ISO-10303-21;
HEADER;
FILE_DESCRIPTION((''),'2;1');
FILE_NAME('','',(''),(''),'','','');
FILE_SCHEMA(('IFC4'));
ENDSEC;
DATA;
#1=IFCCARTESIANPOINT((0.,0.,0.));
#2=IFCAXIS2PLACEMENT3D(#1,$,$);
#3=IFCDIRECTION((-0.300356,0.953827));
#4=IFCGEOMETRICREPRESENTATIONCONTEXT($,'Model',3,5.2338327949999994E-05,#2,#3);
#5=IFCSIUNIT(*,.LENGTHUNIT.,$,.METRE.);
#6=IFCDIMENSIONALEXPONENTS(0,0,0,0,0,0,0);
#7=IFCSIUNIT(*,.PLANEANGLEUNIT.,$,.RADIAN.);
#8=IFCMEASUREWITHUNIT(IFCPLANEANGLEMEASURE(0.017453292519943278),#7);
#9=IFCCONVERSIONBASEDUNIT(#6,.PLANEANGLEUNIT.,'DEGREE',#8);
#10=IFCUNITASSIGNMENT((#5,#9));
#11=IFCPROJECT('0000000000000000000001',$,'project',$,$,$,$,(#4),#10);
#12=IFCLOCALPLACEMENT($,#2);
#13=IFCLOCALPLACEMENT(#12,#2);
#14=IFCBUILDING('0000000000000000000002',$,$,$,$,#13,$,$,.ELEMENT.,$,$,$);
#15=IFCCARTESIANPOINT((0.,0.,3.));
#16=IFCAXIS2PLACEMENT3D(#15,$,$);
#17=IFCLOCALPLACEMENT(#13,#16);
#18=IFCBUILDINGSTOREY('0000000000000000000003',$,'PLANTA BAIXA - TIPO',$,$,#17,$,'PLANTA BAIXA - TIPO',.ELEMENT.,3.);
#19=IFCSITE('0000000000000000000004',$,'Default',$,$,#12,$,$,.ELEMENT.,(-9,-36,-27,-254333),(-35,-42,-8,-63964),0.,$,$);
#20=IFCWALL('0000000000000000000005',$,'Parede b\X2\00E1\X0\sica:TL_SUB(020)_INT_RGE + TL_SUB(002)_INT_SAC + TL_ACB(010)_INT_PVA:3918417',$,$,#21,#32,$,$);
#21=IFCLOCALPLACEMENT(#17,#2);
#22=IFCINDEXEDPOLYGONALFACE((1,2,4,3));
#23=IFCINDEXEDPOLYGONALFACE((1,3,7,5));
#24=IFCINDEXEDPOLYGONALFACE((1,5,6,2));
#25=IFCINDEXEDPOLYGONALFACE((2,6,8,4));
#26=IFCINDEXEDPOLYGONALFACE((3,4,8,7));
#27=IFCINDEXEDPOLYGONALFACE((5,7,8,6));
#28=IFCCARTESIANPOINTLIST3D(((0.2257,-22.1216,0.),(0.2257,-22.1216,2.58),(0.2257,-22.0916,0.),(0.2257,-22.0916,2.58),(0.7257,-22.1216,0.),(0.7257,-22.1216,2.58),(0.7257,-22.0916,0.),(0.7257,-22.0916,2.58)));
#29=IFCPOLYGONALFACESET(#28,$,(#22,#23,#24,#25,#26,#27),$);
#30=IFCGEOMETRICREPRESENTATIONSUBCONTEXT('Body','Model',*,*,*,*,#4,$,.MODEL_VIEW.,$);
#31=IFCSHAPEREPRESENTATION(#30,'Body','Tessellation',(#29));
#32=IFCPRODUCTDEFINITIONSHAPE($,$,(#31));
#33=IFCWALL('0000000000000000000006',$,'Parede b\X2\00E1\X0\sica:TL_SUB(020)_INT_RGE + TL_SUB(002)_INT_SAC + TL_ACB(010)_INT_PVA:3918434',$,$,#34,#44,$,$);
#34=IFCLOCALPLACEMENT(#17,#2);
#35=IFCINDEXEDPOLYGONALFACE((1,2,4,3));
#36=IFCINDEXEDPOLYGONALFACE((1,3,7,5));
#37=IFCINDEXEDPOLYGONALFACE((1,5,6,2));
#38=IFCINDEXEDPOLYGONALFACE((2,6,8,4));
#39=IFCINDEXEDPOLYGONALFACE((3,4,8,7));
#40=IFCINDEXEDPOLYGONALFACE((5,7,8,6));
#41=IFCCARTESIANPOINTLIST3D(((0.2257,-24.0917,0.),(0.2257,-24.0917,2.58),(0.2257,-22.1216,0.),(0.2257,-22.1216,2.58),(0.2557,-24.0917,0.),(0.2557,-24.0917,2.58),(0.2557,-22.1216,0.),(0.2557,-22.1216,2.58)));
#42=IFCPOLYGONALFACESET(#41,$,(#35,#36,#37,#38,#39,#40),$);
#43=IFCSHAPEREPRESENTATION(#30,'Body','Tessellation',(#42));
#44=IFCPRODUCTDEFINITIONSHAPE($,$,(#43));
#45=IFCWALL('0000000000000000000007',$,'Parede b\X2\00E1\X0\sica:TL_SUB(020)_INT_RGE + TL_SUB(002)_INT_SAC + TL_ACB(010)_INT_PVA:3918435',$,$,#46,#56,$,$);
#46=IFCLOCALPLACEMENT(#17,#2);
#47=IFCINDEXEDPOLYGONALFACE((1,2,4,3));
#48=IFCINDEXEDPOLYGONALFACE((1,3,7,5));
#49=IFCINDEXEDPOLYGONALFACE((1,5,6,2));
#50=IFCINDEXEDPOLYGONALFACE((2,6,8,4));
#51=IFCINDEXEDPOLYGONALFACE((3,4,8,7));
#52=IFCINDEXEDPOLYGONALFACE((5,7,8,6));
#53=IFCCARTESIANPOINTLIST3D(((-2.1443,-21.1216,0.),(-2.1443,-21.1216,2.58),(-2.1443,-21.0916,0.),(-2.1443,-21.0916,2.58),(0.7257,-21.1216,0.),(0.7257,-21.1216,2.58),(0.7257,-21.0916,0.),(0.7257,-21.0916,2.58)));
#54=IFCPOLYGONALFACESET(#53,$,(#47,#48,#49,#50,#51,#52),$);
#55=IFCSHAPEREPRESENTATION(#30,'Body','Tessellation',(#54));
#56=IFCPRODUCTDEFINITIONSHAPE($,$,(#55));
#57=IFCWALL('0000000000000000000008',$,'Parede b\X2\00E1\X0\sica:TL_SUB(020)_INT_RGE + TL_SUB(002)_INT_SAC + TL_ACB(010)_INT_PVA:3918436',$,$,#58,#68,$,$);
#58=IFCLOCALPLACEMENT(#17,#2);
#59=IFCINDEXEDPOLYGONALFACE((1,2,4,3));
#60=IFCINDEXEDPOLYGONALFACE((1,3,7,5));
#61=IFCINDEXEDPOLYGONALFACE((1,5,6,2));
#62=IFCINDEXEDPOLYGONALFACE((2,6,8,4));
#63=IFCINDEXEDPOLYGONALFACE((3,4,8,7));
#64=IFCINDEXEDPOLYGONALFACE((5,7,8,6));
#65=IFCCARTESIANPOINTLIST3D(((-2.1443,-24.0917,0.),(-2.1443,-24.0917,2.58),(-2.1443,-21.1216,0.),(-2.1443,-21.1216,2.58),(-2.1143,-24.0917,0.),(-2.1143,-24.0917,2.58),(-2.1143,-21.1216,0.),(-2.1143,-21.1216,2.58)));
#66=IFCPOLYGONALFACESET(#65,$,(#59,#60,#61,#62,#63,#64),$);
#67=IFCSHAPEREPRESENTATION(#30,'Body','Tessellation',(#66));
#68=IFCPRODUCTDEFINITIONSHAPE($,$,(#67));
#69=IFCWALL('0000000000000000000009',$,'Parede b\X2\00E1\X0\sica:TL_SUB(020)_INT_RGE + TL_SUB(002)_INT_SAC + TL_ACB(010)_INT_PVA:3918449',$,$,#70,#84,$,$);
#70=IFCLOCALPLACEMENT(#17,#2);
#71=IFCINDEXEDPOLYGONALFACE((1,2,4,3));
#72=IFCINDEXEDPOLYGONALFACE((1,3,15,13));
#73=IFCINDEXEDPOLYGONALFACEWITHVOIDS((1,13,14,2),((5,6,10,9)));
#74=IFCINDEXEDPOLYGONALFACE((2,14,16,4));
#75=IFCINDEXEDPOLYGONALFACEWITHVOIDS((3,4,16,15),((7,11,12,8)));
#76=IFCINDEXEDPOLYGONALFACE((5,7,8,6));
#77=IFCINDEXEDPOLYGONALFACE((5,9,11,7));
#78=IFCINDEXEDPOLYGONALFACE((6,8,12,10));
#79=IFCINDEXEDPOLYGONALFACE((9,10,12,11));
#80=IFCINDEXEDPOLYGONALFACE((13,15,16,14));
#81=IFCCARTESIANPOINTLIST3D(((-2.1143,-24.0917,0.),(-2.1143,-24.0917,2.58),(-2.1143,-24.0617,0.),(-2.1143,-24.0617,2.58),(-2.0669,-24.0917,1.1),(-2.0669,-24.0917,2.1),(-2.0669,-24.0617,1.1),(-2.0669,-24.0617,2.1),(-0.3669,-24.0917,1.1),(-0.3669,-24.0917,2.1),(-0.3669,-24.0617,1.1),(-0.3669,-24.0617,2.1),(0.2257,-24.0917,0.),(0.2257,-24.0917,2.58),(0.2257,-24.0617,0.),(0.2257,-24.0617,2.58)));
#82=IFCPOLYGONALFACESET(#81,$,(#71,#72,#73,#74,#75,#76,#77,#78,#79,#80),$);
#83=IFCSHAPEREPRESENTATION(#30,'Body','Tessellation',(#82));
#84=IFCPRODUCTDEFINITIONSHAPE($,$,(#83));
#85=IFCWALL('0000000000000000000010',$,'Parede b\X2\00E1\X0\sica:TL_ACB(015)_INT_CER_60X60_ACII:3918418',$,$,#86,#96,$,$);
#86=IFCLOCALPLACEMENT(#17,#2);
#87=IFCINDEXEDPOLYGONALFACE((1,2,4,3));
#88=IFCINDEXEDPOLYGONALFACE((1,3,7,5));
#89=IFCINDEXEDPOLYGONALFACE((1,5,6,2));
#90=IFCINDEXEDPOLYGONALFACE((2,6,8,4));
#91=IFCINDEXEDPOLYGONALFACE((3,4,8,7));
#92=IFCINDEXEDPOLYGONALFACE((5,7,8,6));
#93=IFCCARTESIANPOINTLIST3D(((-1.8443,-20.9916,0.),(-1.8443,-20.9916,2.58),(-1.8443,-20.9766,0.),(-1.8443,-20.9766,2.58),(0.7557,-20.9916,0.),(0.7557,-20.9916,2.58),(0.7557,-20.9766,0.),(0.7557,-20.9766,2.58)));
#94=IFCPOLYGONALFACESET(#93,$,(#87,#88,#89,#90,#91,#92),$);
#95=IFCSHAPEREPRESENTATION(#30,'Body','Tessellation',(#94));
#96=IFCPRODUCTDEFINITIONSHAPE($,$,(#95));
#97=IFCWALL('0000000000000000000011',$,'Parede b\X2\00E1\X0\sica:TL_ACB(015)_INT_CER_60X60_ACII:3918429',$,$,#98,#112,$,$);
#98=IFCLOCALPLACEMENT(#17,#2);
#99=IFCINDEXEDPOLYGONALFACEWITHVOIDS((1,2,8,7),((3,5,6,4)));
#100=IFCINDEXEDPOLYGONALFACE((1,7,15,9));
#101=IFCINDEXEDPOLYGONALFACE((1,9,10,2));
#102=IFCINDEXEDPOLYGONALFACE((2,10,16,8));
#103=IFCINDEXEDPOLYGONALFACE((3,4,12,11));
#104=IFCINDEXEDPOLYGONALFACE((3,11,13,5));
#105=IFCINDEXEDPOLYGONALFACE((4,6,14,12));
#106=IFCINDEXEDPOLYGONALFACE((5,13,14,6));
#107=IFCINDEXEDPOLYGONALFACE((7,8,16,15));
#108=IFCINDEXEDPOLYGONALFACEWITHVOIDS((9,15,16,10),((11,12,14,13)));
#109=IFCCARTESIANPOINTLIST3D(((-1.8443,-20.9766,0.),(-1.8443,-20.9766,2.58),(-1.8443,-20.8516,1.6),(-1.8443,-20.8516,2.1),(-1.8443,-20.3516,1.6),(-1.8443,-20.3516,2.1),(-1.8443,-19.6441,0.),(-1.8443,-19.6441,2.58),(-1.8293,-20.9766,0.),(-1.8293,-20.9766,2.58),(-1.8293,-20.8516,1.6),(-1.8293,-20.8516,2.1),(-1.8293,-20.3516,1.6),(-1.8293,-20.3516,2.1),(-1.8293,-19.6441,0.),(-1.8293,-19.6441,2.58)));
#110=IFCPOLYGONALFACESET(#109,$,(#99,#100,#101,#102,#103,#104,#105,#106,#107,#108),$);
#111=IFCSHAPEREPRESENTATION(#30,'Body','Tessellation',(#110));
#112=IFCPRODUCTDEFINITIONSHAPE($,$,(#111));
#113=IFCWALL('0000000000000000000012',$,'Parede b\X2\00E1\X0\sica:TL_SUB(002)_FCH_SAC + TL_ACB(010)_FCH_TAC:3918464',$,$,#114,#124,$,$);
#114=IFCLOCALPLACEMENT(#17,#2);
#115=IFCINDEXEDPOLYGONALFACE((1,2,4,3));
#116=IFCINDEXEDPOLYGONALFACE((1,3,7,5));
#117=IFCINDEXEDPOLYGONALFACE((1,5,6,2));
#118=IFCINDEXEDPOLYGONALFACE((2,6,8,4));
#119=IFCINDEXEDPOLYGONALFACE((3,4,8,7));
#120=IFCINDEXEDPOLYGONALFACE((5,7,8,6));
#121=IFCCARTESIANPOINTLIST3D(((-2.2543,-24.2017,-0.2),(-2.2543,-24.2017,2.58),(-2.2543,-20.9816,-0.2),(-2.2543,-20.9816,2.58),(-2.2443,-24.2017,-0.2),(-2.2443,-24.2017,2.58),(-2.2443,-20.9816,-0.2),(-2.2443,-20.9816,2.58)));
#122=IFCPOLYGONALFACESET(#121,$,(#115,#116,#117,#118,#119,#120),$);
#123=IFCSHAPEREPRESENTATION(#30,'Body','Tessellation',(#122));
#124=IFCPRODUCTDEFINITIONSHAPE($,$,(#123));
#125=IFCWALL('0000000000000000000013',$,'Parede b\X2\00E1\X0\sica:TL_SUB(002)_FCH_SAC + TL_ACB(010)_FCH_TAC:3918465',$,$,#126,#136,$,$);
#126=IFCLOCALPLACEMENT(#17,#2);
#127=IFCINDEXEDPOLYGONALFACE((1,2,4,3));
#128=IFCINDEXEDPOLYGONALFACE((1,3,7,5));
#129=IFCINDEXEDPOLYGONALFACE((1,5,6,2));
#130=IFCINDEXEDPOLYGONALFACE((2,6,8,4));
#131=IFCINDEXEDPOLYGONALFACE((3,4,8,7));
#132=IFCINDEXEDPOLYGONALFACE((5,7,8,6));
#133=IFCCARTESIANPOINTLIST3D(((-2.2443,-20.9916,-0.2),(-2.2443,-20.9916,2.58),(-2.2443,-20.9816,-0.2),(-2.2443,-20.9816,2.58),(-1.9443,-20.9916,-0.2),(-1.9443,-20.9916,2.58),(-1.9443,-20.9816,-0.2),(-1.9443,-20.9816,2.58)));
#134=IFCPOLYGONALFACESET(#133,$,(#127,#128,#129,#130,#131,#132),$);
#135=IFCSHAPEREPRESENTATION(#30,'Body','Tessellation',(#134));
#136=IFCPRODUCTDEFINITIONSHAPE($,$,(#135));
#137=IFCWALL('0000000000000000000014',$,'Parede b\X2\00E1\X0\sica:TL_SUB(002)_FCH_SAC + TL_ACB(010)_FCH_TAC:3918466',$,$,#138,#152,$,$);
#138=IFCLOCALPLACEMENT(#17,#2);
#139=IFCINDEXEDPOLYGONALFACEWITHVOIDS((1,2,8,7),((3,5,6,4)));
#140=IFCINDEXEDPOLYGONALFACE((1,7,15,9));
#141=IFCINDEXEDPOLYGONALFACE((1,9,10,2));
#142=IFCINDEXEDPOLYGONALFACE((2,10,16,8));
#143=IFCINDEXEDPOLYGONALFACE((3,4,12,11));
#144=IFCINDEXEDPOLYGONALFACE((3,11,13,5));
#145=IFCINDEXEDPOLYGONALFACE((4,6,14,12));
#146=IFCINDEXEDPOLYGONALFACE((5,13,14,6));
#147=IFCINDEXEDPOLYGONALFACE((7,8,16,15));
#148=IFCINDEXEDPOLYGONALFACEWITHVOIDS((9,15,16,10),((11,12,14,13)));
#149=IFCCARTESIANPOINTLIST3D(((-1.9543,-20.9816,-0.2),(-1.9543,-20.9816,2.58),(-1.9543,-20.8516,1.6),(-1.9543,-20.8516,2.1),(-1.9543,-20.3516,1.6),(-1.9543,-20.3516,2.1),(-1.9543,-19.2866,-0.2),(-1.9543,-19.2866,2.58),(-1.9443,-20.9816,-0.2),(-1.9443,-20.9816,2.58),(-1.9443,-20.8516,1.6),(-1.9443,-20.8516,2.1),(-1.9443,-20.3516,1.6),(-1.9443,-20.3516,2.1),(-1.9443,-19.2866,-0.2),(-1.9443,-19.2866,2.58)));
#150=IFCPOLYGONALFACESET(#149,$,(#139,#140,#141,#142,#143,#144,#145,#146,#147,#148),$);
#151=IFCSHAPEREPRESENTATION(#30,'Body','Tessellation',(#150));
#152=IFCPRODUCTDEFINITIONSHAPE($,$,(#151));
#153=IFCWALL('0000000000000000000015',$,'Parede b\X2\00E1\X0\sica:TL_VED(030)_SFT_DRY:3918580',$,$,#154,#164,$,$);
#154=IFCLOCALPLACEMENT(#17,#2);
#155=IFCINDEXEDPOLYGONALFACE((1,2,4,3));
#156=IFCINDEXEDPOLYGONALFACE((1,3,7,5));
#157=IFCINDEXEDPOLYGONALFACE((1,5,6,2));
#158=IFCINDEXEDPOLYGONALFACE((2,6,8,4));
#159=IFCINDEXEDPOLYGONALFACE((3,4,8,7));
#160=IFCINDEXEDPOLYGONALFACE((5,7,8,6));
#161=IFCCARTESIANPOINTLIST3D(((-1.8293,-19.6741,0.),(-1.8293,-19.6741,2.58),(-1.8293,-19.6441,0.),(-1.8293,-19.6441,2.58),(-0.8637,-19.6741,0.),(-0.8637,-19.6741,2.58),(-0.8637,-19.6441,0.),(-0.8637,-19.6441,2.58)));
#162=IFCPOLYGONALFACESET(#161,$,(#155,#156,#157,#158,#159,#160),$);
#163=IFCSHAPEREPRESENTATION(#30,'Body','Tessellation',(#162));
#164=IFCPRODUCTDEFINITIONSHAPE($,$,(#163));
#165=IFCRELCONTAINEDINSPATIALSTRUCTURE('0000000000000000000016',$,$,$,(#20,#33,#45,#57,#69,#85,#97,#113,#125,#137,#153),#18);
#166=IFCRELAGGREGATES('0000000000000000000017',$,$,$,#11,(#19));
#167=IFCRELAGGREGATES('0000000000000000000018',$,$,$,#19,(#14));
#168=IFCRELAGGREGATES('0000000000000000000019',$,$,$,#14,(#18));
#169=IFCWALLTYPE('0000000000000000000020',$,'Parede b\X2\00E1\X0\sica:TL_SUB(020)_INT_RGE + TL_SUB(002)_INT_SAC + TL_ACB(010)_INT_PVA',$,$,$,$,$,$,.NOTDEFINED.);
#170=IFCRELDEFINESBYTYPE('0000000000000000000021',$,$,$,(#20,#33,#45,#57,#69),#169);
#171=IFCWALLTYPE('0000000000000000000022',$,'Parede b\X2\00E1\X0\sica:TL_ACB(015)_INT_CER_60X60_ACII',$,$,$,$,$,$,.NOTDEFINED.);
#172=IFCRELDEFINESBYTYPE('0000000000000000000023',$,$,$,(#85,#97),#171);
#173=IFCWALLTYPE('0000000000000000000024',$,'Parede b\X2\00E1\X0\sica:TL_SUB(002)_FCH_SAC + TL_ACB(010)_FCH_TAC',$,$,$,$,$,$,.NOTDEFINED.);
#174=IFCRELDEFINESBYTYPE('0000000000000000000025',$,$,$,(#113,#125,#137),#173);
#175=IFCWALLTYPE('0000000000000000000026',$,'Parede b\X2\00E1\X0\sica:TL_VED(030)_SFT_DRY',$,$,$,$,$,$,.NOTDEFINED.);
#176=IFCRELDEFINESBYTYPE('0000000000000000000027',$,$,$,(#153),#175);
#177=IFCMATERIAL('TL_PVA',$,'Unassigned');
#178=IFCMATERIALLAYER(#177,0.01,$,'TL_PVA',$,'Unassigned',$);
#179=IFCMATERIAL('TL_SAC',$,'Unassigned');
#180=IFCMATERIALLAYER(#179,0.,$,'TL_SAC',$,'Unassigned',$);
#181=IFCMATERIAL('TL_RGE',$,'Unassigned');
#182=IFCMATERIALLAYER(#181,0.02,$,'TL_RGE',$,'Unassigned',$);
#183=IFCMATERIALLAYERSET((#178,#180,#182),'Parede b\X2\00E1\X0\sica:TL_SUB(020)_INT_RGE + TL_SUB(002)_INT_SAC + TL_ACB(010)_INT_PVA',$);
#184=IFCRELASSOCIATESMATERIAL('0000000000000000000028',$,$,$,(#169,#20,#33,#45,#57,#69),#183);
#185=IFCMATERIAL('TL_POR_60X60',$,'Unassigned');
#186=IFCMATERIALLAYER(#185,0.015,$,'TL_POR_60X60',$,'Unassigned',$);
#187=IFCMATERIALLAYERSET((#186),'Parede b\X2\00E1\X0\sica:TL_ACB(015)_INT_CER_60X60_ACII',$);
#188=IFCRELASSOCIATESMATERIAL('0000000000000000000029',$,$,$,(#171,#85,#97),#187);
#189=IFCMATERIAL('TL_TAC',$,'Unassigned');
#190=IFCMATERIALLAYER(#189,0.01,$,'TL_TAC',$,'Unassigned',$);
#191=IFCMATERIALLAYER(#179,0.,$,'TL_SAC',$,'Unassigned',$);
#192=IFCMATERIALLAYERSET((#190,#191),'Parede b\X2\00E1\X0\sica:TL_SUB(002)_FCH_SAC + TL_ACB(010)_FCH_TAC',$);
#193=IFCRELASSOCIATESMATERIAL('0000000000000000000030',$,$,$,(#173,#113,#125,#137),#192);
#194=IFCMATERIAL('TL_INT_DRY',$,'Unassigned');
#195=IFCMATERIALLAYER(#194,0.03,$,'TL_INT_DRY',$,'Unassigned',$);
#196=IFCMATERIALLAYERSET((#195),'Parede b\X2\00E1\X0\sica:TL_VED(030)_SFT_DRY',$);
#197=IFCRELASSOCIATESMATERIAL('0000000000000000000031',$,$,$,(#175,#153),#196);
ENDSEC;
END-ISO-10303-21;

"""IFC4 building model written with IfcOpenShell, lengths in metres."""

from ifc_helpers import new_model, entity, si_unit, converted_unit, direction, frame, frame_2d, origin, place, context, subcontext, project, spatial, rectangle, extrude, material, layer, layer_set, layer_usage, type_object, element, save


model = new_model("IFC4")

# Units and contexts
model_context = context("Model", 3, precision=5.2338327949999994e-05, world=origin(), true_north=direction((-0.300356, 0.953827)))
body_context = subcontext(model_context, "Body", "Model", "MODEL_VIEW")
ifc_project = project(units=[si_unit("LENGTHUNIT", "METRE"), converted_unit("PLANEANGLEUNIT", "DEGREE", entity("IfcPlaneAngleMeasure", 0.017453292519943278), si_unit("PLANEANGLEUNIT", "RADIAN"), dimensions=[0, 0, 0, 0, 0, 0, 0])], contexts=[model_context])

# Site, building, storey
site_placement = place(None, origin())
site = spatial("IfcSite", under=ifc_project, at=site_placement, Name="Default", CompositionType="ELEMENT", RefLatitude=(-9, -36, -27, -254333), RefLongitude=(-35, -42, -8, -63964), RefElevation=0.0)
building_placement = place(site_placement, origin())
building = spatial("IfcBuilding", under=site, at=building_placement, CompositionType="ELEMENT")
storey_placement = place(building_placement, frame((0.0, 0.0, 3.0)))
storey = spatial("IfcBuildingStorey", under=building, at=storey_placement, Name="PLANTA BAIXA - TIPO", LongName="PLANTA BAIXA - TIPO", CompositionType="ELEMENT", Elevation=3.0)

# Shared definitions
ifc_material_1 = material(Name="TL_POR_60X60", Category="Unassigned")

# Walls
ifc_material_2 = material(Name="TL_PVA", Category="Unassigned")
ifc_layer_1 = layer(ifc_material_2, 0.01, Name="TL_PVA", Category="Unassigned")
ifc_material_3 = material(Name="TL_SAC", Category="Unassigned")
ifc_layer_2 = layer(ifc_material_3, 0.0, Name="TL_SAC", Category="Unassigned")
ifc_material_4 = material(Name="TL_RGE", Category="Unassigned")
ifc_layer_3 = layer(ifc_material_4, 0.02, Name="TL_RGE", Category="Unassigned")
ifc_layer_set_1 = layer_set([ifc_layer_1, ifc_layer_2, ifc_layer_3], Name="Parede básica:TL_SUB(020)_INT_RGE + TL_SUB(002)_INT_SAC + TL_ACB(010)_INT_PVA")
ifc_layer_usage_1 = layer_usage(ifc_layer_set_1, "AXIS2", "NEGATIVE", 0.015)
wall_type_1 = type_object("IfcWallType", Name="Parede básica:TL_SUB(020)_INT_RGE + TL_SUB(002)_INT_SAC + TL_ACB(010)_INT_PVA", PredefinedType="NOTDEFINED", material=ifc_layer_set_1)
wall_1_placement = place(storey_placement, frame((0.2257, -22.1066, 0.0)))
element("IfcWall", 1, at=wall_1_placement, inside=storey, type_object=wall_type_1, material=ifc_layer_usage_1, Name="Parede básica:TL_SUB(020)_INT_RGE + TL_SUB(002)_INT_SAC + TL_ACB(010)_INT_PVA:3918417", context=body_context, shape_type="SweptSolid", body=[
    extrude(rectangle(XDim=0.5, YDim=0.03, at=frame_2d((0.25, 0.0), x_axis=(-1.0, 0.0))), origin(), (0.0, 0.0, 1.0), 2.58),
])
ifc_layer_usage_2 = layer_usage(ifc_layer_set_1, "AXIS2", "POSITIVE", -0.015)
wall_2_placement = place(storey_placement, frame((0.2407, -22.1216, 0.0), z_axis=(0.0, 0.0, 1.0), x_axis=(0.0, -1.0, 0.0)))
element("IfcWall", 2, at=wall_2_placement, inside=storey, type_object=wall_type_1, material=ifc_layer_usage_2, Name="Parede básica:TL_SUB(020)_INT_RGE + TL_SUB(002)_INT_SAC + TL_ACB(010)_INT_PVA:3918434", context=body_context, shape_type="SweptSolid", body=[
    extrude(rectangle(XDim=1.9701, YDim=0.03, at=frame_2d((0.9851, 0.0), x_axis=(-1.0, 0.0))), origin(), (0.0, 0.0, 1.0), 2.58),
])
ifc_layer_usage_3 = layer_usage(ifc_layer_set_1, "AXIS2", "POSITIVE", -0.015)
wall_3_placement = place(storey_placement, frame((-2.1443, -21.1066, 0.0)))
element("IfcWall", 3, at=wall_3_placement, inside=storey, type_object=wall_type_1, material=ifc_layer_usage_3, Name="Parede básica:TL_SUB(020)_INT_RGE + TL_SUB(002)_INT_SAC + TL_ACB(010)_INT_PVA:3918435", context=body_context, shape_type="SweptSolid", body=[
    extrude(rectangle(XDim=2.87, YDim=0.03, at=frame_2d((1.435, 0.0), x_axis=(-1.0, 0.0))), origin(), (0.0, 0.0, 1.0), 2.58),
])
ifc_layer_usage_4 = layer_usage(ifc_layer_set_1, "AXIS2", "POSITIVE", -0.015)
wall_4_placement = place(storey_placement, frame((-2.1293, -24.0917, 0.0), z_axis=(0.0, 0.0, 1.0), x_axis=(0.0, 1.0, 0.0)))
element("IfcWall", 4, at=wall_4_placement, inside=storey, type_object=wall_type_1, material=ifc_layer_usage_4, Name="Parede básica:TL_SUB(020)_INT_RGE + TL_SUB(002)_INT_SAC + TL_ACB(010)_INT_PVA:3918436", context=body_context, shape_type="SweptSolid", body=[
    extrude(rectangle(XDim=2.9701, YDim=0.03, at=frame_2d((1.4851, 0.0), x_axis=(-1.0, 0.0))), origin(), (0.0, 0.0, 1.0), 2.58),
])

# Wall, opening
ifc_layer_usage_5 = layer_usage(ifc_layer_set_1, "AXIS2", "POSITIVE", -0.015)
wall_5_placement = place(storey_placement, frame((0.2257, -24.0767, 0.0), z_axis=(0.0, 0.0, 1.0), x_axis=(-1.0, 0.0, 0.0)))
wall_5 = element("IfcWall", 5, at=wall_5_placement, inside=storey, type_object=wall_type_1, material=ifc_layer_usage_5, Name="Parede básica:TL_SUB(020)_INT_RGE + TL_SUB(002)_INT_SAC + TL_ACB(010)_INT_PVA:3918449", context=body_context, shape_type="SweptSolid", body=[
    extrude(rectangle(XDim=2.34, YDim=0.03, at=frame_2d((1.17, 0.0), x_axis=(-1.0, 0.0))), origin(), (0.0, 0.0, 1.0), 2.58),
])
opening_1_placement = place(wall_5_placement, frame((0.2257, -24.0767, 1.1)))
element("IfcOpeningElement", 6, at=opening_1_placement, cuts=wall_5, PredefinedType="OPENING", context=body_context, shape_type="SweptSolid", body=[
    extrude(rectangle(XDim=1.0, YDim=1.7, at=frame_2d((0.0, 0.0), x_axis=(0.0, 1.0))), frame((1.2169, 22.5677, 0.5), z_axis=(0.0, 1.0, 0.0), x_axis=(1.0, 0.0, 0.0)), (0.0, 0.0, 1.0), 3.048),
])

# Wall
ifc_layer_4 = layer(ifc_material_1, 0.015, Name="TL_POR_60X60", Category="Unassigned")
ifc_layer_set_2 = layer_set([ifc_layer_4], Name="Parede básica:TL_ACB(015)_INT_CER_60X60_ACII")
ifc_layer_usage_6 = layer_usage(ifc_layer_set_2, "AXIS2", "NEGATIVE", 0.0075)
wall_type_2 = type_object("IfcWallType", Name="Parede básica:TL_ACB(015)_INT_CER_60X60_ACII", PredefinedType="NOTDEFINED", material=ifc_layer_set_2)
wall_6_placement = place(storey_placement, frame((-1.8443, -20.9841, 0.0)))
element("IfcWall", 7, at=wall_6_placement, inside=storey, type_object=wall_type_2, material=ifc_layer_usage_6, Name="Parede básica:TL_ACB(015)_INT_CER_60X60_ACII:3918418", context=body_context, shape_type="SweptSolid", body=[
    extrude(rectangle(XDim=2.6, YDim=0.015, at=frame_2d((1.3, 0.0), x_axis=(-1.0, 0.0))), origin(), (0.0, 0.0, 1.0), 2.58),
])

# Wall, opening
ifc_layer_usage_7 = layer_usage(ifc_layer_set_2, "AXIS2", "POSITIVE", -0.0075)
wall_7_placement = place(storey_placement, frame((-1.8368, -20.9766, 0.0), z_axis=(0.0, 0.0, 1.0), x_axis=(0.0, 1.0, 0.0)))
wall_7 = element("IfcWall", 8, at=wall_7_placement, inside=storey, type_object=wall_type_2, material=ifc_layer_usage_7, Name="Parede básica:TL_ACB(015)_INT_CER_60X60_ACII:3918429", context=body_context, shape_type="SweptSolid", body=[
    extrude(rectangle(XDim=1.3325, YDim=0.015, at=frame_2d((0.6662, 0.0), x_axis=(-1.0, 0.0))), origin(), (0.0, 0.0, 1.0), 2.58),
])
opening_2_placement = place(wall_7_placement, frame((20.9766, -1.8368, 1.6)))
element("IfcOpeningElement", 9, at=opening_2_placement, cuts=wall_7, PredefinedType="OPENING", context=body_context, shape_type="SweptSolid", body=[
    extrude(rectangle(XDim=0.5, YDim=0.5, at=frame_2d((0.0, 0.0), x_axis=(1.0, 0.0))), frame((-20.6016, 0.4203, 0.25), z_axis=(0.0, 1.0, 0.0), x_axis=(0.0, 0.0, 1.0)), (0.0, 0.0, 1.0), 3.048),
])

# Walls
ifc_material_5 = material(Name="TL_TAC", Category="Unassigned")
ifc_layer_5 = layer(ifc_material_5, 0.01, Name="TL_TAC", Category="Unassigned")
ifc_layer_6 = layer(ifc_material_3, 0.0, Name="TL_SAC", Category="Unassigned")
ifc_layer_set_3 = layer_set([ifc_layer_5, ifc_layer_6], Name="Parede básica:TL_SUB(002)_FCH_SAC + TL_ACB(010)_FCH_TAC")
ifc_layer_usage_8 = layer_usage(ifc_layer_set_3, "AXIS2", "POSITIVE", -0.005)
wall_type_3 = type_object("IfcWallType", Name="Parede básica:TL_SUB(002)_FCH_SAC + TL_ACB(010)_FCH_TAC", PredefinedType="NOTDEFINED", material=ifc_layer_set_3)
wall_8_placement = place(storey_placement, frame((-2.2493, -24.2017, -0.2), z_axis=(0.0, 0.0, 1.0), x_axis=(0.0, 1.0, 0.0)))
element("IfcWall", 10, at=wall_8_placement, inside=storey, type_object=wall_type_3, material=ifc_layer_usage_8, Name="Parede básica:TL_SUB(002)_FCH_SAC + TL_ACB(010)_FCH_TAC:3918464", context=body_context, shape_type="SweptSolid", body=[
    extrude(rectangle(XDim=3.2201, YDim=0.01, at=frame_2d((1.6101, 0.0), x_axis=(-1.0, 0.0))), origin(), (0.0, 0.0, 1.0), 2.78),
])
ifc_layer_usage_9 = layer_usage(ifc_layer_set_3, "AXIS2", "POSITIVE", -0.005)
wall_9_placement = place(storey_placement, frame((-2.2443, -20.9866, -0.2)))
element("IfcWall", 11, at=wall_9_placement, inside=storey, type_object=wall_type_3, material=ifc_layer_usage_9, Name="Parede básica:TL_SUB(002)_FCH_SAC + TL_ACB(010)_FCH_TAC:3918465", context=body_context, shape_type="SweptSolid", body=[
    extrude(rectangle(XDim=0.3, YDim=0.01, at=frame_2d((0.15, 0.0), x_axis=(-1.0, 0.0))), origin(), (0.0, 0.0, 1.0), 2.78),
])

# Wall, opening
ifc_layer_usage_10 = layer_usage(ifc_layer_set_3, "AXIS2", "POSITIVE", -0.005)
wall_10_placement = place(storey_placement, frame((-1.9493, -20.9816, -0.2), z_axis=(0.0, 0.0, 1.0), x_axis=(0.0, 1.0, 0.0)))
wall_10 = element("IfcWall", 12, at=wall_10_placement, inside=storey, type_object=wall_type_3, material=ifc_layer_usage_10, Name="Parede básica:TL_SUB(002)_FCH_SAC + TL_ACB(010)_FCH_TAC:3918466", context=body_context, shape_type="SweptSolid", body=[
    extrude(rectangle(XDim=1.695, YDim=0.01, at=frame_2d((0.8475, 0.0), x_axis=(-1.0, 0.0))), origin(), (0.0, 0.0, 1.0), 2.78),
])
opening_3_placement = place(wall_10_placement, frame((20.9816, -1.9493, 1.8)))
element("IfcOpeningElement", 13, at=opening_3_placement, cuts=wall_10, PredefinedType="OPENING", context=body_context, shape_type="SweptSolid", body=[
    extrude(rectangle(XDim=0.5, YDim=0.5, at=frame_2d((0.0, 0.0), x_axis=(1.0, 0.0))), frame((-20.6016, 0.4203, 0.25), z_axis=(0.0, 1.0, 0.0), x_axis=(0.0, 0.0, 1.0)), (0.0, 0.0, 1.0), 3.048),
])

# Wall
ifc_material_6 = material(Name="TL_INT_DRY", Category="Unassigned")
ifc_layer_7 = layer(ifc_material_6, 0.03, Name="TL_INT_DRY", Category="Unassigned")
ifc_layer_set_4 = layer_set([ifc_layer_7], Name="Parede básica:TL_VED(030)_SFT_DRY")
ifc_layer_usage_11 = layer_usage(ifc_layer_set_4, "AXIS2", "POSITIVE", -0.015)
wall_type_4 = type_object("IfcWallType", Name="Parede básica:TL_VED(030)_SFT_DRY", PredefinedType="NOTDEFINED", material=ifc_layer_set_4)
wall_11_placement = place(storey_placement, frame((-1.8293, -19.6591, 0.0)))
element("IfcWall", 14, at=wall_11_placement, inside=storey, type_object=wall_type_4, material=ifc_layer_usage_11, Name="Parede básica:TL_VED(030)_SFT_DRY:3918580", context=body_context, shape_type="SweptSolid", body=[
    extrude(rectangle(XDim=0.9655, YDim=0.03, at=frame_2d((0.4828, 0.0), x_axis=(-1.0, 0.0))), origin(), (0.0, 0.0, 1.0), 2.58),
])

save(model, "model.ifc")
